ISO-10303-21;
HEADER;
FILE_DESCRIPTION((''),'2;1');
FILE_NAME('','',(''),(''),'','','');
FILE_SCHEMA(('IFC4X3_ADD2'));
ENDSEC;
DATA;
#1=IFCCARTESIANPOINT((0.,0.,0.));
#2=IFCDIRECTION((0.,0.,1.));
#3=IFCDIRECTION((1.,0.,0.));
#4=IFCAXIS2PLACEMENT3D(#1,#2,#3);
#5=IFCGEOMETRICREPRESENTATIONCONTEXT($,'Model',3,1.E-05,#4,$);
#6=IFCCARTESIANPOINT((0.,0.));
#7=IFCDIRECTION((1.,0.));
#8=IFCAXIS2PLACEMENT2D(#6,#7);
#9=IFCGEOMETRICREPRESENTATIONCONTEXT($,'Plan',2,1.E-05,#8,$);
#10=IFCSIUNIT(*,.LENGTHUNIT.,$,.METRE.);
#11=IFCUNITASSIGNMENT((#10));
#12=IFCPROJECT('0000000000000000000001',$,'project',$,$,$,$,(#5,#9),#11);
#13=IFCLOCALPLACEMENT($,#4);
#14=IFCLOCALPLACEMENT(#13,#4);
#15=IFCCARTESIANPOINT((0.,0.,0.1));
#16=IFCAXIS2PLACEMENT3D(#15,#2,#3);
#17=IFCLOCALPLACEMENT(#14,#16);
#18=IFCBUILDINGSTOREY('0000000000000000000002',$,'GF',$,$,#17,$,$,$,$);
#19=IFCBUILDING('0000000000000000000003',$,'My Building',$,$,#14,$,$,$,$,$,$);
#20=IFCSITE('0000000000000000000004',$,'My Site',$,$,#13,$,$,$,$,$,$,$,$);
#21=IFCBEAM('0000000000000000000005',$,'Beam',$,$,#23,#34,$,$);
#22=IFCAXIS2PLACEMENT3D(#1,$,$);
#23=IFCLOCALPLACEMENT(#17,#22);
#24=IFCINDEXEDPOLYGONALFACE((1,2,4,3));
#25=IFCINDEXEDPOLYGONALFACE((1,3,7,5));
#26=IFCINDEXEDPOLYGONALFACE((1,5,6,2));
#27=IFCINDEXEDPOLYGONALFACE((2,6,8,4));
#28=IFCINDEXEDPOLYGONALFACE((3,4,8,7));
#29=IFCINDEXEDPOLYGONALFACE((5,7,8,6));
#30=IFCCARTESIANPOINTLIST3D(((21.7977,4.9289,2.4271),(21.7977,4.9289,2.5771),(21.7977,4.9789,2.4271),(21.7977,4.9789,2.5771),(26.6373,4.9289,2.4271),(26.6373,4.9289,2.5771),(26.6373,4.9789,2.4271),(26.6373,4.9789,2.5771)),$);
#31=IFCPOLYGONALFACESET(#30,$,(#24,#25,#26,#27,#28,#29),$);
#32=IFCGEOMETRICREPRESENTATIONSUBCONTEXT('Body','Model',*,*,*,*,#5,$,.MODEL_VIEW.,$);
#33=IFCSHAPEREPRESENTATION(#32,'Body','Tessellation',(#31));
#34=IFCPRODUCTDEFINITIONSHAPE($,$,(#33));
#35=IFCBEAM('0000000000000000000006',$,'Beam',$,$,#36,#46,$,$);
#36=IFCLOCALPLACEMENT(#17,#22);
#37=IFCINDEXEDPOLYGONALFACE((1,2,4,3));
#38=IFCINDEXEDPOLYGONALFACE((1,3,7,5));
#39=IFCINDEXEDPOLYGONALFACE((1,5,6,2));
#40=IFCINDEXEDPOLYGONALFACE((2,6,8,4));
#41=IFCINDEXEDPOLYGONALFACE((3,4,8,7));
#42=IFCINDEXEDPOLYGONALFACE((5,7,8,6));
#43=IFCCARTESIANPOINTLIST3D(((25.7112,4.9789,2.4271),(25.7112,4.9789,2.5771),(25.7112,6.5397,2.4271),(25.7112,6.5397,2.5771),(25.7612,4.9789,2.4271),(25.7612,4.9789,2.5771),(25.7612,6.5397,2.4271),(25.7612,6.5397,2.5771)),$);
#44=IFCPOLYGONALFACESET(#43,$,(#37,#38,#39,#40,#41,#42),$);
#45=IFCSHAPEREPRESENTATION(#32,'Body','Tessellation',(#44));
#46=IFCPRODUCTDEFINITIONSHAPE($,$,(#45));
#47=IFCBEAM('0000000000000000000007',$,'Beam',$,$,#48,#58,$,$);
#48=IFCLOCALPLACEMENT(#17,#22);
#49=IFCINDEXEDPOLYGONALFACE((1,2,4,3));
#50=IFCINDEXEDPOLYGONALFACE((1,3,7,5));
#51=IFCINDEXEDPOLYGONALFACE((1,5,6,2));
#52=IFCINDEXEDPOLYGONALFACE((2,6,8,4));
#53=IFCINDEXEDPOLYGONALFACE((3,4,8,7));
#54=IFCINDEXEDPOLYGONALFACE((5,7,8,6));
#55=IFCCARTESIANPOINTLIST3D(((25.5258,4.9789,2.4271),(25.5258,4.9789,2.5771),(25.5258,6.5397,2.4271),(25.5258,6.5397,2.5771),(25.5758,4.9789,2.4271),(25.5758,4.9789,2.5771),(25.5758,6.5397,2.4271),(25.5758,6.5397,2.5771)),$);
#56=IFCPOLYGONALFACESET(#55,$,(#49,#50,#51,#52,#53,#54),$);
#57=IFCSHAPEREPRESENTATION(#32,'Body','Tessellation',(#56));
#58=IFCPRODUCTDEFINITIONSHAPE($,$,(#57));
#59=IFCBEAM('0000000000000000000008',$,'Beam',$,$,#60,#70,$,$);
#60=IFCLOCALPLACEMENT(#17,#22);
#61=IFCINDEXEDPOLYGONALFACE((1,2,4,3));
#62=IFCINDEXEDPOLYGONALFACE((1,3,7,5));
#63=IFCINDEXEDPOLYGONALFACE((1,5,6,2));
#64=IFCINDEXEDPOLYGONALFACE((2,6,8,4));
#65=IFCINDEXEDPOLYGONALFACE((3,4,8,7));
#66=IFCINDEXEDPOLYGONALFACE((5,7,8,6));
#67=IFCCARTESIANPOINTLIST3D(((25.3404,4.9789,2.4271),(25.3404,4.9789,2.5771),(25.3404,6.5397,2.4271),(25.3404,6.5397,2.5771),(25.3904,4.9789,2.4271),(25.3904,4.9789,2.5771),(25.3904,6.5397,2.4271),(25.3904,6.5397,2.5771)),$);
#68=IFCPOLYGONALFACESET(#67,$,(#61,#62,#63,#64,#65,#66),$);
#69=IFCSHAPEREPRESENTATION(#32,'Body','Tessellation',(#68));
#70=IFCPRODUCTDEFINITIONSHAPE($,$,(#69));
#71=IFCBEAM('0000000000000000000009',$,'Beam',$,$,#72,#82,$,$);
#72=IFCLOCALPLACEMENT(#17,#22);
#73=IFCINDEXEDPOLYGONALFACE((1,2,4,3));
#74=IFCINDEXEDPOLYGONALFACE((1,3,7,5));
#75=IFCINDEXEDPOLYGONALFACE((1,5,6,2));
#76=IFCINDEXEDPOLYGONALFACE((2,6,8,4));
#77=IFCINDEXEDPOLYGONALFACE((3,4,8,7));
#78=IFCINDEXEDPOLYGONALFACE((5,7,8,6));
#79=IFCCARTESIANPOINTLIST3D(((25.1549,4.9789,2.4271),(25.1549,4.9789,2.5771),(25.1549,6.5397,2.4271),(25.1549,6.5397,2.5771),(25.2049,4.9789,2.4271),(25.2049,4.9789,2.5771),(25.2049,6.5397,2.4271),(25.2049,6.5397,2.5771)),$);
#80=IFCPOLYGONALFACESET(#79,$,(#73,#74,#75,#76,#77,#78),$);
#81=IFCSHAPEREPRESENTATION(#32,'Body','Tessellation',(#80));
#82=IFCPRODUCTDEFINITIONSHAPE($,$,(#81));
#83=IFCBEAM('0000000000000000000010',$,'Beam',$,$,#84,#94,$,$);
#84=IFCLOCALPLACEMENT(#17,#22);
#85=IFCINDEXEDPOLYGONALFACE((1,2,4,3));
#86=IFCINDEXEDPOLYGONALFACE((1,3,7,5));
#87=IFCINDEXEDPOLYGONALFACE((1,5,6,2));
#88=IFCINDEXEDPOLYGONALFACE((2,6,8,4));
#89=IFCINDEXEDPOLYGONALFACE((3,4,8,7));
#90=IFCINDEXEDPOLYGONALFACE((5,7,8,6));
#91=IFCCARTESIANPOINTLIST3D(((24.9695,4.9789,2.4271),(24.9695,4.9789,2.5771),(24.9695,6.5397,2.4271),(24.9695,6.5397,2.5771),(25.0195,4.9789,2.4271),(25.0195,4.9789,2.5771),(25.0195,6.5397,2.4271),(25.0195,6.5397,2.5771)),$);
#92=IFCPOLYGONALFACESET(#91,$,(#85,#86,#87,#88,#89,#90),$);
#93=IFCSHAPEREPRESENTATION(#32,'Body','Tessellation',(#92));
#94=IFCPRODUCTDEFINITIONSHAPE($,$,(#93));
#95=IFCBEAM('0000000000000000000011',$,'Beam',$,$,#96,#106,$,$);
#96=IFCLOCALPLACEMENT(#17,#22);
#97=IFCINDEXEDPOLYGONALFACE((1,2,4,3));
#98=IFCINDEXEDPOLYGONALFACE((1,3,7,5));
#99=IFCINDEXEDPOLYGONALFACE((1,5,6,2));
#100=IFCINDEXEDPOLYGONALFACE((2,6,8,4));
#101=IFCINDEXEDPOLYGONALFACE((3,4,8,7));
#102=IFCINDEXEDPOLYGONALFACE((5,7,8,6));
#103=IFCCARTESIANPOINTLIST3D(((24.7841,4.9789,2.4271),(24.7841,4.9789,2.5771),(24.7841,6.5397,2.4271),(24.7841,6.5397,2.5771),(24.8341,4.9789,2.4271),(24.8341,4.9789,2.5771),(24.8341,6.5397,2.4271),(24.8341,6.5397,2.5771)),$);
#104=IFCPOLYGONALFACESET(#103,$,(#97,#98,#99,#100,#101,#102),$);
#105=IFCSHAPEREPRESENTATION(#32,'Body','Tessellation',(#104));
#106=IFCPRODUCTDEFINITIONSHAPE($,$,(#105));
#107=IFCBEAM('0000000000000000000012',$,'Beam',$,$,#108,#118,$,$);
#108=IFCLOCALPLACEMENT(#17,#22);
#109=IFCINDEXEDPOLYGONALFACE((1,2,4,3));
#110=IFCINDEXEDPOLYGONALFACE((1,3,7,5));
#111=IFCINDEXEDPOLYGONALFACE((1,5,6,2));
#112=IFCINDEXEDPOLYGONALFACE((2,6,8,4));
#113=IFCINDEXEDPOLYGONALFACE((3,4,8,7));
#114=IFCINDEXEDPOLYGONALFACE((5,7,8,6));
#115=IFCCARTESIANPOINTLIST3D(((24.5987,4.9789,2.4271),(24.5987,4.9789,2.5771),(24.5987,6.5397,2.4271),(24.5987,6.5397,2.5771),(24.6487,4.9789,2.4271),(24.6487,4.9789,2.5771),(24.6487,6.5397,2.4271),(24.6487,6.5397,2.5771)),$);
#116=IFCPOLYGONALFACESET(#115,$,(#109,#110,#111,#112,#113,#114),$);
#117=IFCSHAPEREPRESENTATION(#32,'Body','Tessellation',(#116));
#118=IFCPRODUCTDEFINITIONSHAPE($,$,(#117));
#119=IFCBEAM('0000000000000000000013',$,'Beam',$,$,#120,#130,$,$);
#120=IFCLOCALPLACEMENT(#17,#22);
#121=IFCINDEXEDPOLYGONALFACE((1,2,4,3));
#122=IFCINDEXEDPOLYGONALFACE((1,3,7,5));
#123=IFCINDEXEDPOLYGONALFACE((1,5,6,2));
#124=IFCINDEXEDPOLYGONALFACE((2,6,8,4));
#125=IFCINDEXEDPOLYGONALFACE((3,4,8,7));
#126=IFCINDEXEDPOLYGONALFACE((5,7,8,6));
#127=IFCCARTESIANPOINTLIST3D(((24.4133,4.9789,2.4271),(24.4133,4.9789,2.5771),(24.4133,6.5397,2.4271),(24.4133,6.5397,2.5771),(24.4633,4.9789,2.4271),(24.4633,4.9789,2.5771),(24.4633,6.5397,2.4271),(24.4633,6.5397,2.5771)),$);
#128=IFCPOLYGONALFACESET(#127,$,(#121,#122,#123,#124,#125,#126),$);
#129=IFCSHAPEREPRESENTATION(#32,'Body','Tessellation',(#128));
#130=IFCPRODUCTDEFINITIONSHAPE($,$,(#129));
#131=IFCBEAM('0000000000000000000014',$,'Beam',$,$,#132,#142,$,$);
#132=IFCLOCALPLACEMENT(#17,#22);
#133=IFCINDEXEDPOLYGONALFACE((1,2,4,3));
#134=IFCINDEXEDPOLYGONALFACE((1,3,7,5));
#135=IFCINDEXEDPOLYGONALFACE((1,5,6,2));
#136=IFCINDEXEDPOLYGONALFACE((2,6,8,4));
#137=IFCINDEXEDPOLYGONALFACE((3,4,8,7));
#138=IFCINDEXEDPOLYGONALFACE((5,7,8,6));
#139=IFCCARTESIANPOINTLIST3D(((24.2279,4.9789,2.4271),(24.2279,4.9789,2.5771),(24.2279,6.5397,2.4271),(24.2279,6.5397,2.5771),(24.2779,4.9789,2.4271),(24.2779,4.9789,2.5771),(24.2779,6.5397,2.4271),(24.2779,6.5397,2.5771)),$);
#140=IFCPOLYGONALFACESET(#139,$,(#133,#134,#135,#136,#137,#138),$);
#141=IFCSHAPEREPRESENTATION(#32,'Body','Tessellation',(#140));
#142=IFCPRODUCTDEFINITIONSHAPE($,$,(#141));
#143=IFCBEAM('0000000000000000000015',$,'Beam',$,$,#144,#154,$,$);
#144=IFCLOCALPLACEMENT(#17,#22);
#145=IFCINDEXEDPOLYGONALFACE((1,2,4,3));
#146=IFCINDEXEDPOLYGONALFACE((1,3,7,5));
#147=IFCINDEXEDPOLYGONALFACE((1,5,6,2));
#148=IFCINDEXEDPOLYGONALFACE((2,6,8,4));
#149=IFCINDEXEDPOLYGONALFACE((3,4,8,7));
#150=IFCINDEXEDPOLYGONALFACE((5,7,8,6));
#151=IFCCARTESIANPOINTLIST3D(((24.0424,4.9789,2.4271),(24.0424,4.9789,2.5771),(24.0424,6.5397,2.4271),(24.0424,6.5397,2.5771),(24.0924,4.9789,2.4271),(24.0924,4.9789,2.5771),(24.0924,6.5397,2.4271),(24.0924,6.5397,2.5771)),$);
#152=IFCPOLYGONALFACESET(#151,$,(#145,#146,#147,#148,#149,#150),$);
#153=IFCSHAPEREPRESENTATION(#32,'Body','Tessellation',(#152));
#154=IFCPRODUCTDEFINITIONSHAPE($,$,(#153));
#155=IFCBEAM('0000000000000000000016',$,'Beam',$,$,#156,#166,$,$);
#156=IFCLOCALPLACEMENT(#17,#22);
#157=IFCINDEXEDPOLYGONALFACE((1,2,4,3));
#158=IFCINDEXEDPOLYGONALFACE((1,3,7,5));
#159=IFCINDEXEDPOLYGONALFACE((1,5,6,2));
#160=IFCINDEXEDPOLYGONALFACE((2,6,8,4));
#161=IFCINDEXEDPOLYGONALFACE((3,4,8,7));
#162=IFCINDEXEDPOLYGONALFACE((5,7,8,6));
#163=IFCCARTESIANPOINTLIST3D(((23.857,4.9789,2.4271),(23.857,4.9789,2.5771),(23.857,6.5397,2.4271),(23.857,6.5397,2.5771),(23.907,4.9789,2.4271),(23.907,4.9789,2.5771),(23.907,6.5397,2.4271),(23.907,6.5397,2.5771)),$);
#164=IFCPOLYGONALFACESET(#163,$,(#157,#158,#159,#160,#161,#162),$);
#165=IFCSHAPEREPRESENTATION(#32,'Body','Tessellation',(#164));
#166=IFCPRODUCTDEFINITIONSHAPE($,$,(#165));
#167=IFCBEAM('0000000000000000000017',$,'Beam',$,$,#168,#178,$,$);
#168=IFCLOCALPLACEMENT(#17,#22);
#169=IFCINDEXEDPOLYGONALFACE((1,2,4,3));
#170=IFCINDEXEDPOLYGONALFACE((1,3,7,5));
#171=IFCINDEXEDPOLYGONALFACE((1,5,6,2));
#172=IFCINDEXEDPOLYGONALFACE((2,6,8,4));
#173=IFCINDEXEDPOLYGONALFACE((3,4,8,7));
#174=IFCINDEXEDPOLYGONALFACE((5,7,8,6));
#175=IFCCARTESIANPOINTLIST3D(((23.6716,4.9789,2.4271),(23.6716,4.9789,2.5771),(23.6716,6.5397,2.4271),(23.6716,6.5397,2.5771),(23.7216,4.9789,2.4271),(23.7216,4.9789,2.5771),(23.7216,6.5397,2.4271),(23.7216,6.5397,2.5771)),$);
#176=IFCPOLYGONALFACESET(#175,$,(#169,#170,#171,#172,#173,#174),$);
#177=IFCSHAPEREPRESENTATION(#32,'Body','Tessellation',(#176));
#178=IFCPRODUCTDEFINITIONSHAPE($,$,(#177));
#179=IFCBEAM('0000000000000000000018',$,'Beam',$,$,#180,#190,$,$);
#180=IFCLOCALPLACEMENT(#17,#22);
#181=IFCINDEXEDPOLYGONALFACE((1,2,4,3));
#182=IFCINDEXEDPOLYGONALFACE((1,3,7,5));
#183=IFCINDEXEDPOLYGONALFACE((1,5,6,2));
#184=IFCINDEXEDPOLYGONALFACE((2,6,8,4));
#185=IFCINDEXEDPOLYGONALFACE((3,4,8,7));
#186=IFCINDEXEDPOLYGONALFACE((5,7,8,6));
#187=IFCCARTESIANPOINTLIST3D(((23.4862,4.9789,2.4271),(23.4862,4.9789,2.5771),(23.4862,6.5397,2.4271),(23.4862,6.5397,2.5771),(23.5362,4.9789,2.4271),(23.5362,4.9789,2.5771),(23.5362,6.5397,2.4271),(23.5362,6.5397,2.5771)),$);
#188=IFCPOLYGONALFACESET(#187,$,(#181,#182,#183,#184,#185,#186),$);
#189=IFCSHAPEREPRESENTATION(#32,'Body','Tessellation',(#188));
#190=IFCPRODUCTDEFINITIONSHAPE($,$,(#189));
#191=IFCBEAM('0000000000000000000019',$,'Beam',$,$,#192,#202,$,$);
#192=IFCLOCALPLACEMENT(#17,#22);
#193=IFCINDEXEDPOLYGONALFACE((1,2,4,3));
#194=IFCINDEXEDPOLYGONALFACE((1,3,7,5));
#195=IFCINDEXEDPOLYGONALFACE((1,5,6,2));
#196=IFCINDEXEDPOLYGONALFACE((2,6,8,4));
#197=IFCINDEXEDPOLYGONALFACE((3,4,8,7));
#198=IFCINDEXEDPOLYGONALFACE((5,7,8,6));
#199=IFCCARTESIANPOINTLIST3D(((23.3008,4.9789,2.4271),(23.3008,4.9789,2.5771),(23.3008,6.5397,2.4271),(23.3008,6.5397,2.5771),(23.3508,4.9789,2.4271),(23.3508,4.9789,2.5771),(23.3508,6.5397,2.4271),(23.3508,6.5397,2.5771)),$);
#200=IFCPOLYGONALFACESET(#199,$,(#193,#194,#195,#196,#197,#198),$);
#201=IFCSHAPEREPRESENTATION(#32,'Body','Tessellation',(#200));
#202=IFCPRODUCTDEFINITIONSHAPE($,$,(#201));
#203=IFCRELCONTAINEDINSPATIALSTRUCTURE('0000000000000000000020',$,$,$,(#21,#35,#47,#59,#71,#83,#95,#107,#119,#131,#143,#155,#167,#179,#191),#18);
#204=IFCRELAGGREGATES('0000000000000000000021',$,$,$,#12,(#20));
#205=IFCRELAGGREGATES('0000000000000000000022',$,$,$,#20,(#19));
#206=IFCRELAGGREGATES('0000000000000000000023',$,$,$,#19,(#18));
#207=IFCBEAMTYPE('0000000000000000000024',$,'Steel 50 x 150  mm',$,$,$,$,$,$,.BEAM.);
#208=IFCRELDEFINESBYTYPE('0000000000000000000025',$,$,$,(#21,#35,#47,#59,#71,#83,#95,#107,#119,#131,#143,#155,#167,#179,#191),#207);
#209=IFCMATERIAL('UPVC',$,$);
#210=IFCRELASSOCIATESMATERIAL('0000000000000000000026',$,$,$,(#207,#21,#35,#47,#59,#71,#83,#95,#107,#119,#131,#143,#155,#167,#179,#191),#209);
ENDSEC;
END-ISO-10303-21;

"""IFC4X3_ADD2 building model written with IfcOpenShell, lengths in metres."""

from ifc_helpers import new_model, si_unit, frame, origin_with_axes, origin_2d_with_axis, place, context, subcontext, project, spatial, rectangle, extrude, material, material_profile, profile_set, profile_usage, type_object, element, save


model = new_model("IFC4X3_ADD2")

# Units and contexts
model_context = context("Model", 3, precision=1e-05, world=origin_with_axes())
plan_context = context("Plan", 2, precision=1e-05, world=origin_2d_with_axis())
body_context_1 = subcontext(model_context, "Body", "Model", "MODEL_VIEW")
ifc_project = project(units=[si_unit("LENGTHUNIT", "METRE")], contexts=[model_context, plan_context])

# Site, building, storey
site_placement = place(None, origin_with_axes())
site = spatial("IfcSite", under=ifc_project, at=site_placement, Name="My Site")
building_placement = place(site_placement, origin_with_axes())
building = spatial("IfcBuilding", under=site, at=building_placement, Name="My Building")
storey_placement = place(building_placement, frame((0.0, 0.0, 0.1), z_axis=(0.0, 0.0, 1.0), x_axis=(1.0, 0.0, 0.0)))
storey = spatial("IfcBuildingStorey", under=building, at=storey_placement, Name="GF")

# Beams
ifc_material_1 = material(Name="UPVC")
ifc_material_profile_1 = material_profile(ifc_material_1, rectangle(XDim=0.05, YDim=0.15))
ifc_profile_set_1 = profile_set([ifc_material_profile_1])
ifc_profile_usage_1 = profile_usage(ifc_profile_set_1)
beam_type_1 = type_object("IfcBeamType", Name="Steel 50 x 150  mm", PredefinedType="BEAM", material=ifc_profile_set_1)
beam_1_placement = place(storey_placement, frame((21.7977, 4.9539, 2.5021), z_axis=(1.0, 0.0, 0.0), x_axis=(0.0, 1.0, 0.0)))
element("IfcBeam", 1, at=beam_1_placement, inside=storey, type_object=beam_type_1, material=ifc_profile_usage_1, Name="Beam", context=body_context_1, shape_type="SweptSolid", body=[
    extrude(rectangle(XDim=0.05, YDim=0.15), origin_with_axes(), (0.0, 0.0, 1.0), 4.8396),
])
ifc_profile_usage_2 = profile_usage(ifc_profile_set_1)
beam_2_placement = place(storey_placement, frame((25.7362, 6.5397, 2.5021), z_axis=(0.0, -1.0, 0.0), x_axis=(1.0, 0.0, 0.0)))
element("IfcBeam", 2, at=beam_2_placement, inside=storey, type_object=beam_type_1, material=ifc_profile_usage_2, Name="Beam", context=body_context_1, shape_type="SweptSolid", body=[
    extrude(rectangle(XDim=0.05, YDim=0.15), origin_with_axes(), (0.0, 0.0, 1.0), 1.5608),
])
ifc_profile_usage_3 = profile_usage(ifc_profile_set_1)
beam_3_placement = place(storey_placement, frame((25.5508, 6.5397, 2.5021), z_axis=(0.0, -1.0, 0.0), x_axis=(1.0, 0.0, 0.0)))
element("IfcBeam", 3, at=beam_3_placement, inside=storey, type_object=beam_type_1, material=ifc_profile_usage_3, Name="Beam", context=body_context_1, shape_type="SweptSolid", body=[
    extrude(rectangle(XDim=0.05, YDim=0.15), origin_with_axes(), (0.0, 0.0, 1.0), 1.5608),
])
ifc_profile_usage_4 = profile_usage(ifc_profile_set_1)
beam_4_placement = place(storey_placement, frame((25.3654, 6.5397, 2.5021), z_axis=(0.0, -1.0, 0.0), x_axis=(1.0, 0.0, 0.0)))
element("IfcBeam", 4, at=beam_4_placement, inside=storey, type_object=beam_type_1, material=ifc_profile_usage_4, Name="Beam", context=body_context_1, shape_type="SweptSolid", body=[
    extrude(rectangle(XDim=0.05, YDim=0.15), origin_with_axes(), (0.0, 0.0, 1.0), 1.5608),
])
ifc_profile_usage_5 = profile_usage(ifc_profile_set_1)
beam_5_placement = place(storey_placement, frame((25.1799, 6.5397, 2.5021), z_axis=(0.0, -1.0, 0.0), x_axis=(1.0, 0.0, 0.0)))
element("IfcBeam", 5, at=beam_5_placement, inside=storey, type_object=beam_type_1, material=ifc_profile_usage_5, Name="Beam", context=body_context_1, shape_type="SweptSolid", body=[
    extrude(rectangle(XDim=0.05, YDim=0.15), origin_with_axes(), (0.0, 0.0, 1.0), 1.5608),
])
ifc_profile_usage_6 = profile_usage(ifc_profile_set_1)
beam_6_placement = place(storey_placement, frame((24.9945, 6.5397, 2.5021), z_axis=(0.0, -1.0, 0.0), x_axis=(1.0, 0.0, 0.0)))
element("IfcBeam", 6, at=beam_6_placement, inside=storey, type_object=beam_type_1, material=ifc_profile_usage_6, Name="Beam", context=body_context_1, shape_type="SweptSolid", body=[
    extrude(rectangle(XDim=0.05, YDim=0.15), origin_with_axes(), (0.0, 0.0, 1.0), 1.5608),
])
ifc_profile_usage_7 = profile_usage(ifc_profile_set_1)
beam_7_placement = place(storey_placement, frame((24.8091, 6.5397, 2.5021), z_axis=(0.0, -1.0, 0.0), x_axis=(1.0, 0.0, 0.0)))
element("IfcBeam", 7, at=beam_7_placement, inside=storey, type_object=beam_type_1, material=ifc_profile_usage_7, Name="Beam", context=body_context_1, shape_type="SweptSolid", body=[
    extrude(rectangle(XDim=0.05, YDim=0.15), origin_with_axes(), (0.0, 0.0, 1.0), 1.5608),
])
ifc_profile_usage_8 = profile_usage(ifc_profile_set_1)
beam_8_placement = place(storey_placement, frame((24.6237, 6.5397, 2.5021), z_axis=(0.0, -1.0, 0.0), x_axis=(1.0, 0.0, 0.0)))
element("IfcBeam", 8, at=beam_8_placement, inside=storey, type_object=beam_type_1, material=ifc_profile_usage_8, Name="Beam", context=body_context_1, shape_type="SweptSolid", body=[
    extrude(rectangle(XDim=0.05, YDim=0.15), origin_with_axes(), (0.0, 0.0, 1.0), 1.5608),
])
ifc_profile_usage_9 = profile_usage(ifc_profile_set_1)
beam_9_placement = place(storey_placement, frame((24.4383, 6.5397, 2.5021), z_axis=(0.0, -1.0, 0.0), x_axis=(1.0, 0.0, 0.0)))
element("IfcBeam", 9, at=beam_9_placement, inside=storey, type_object=beam_type_1, material=ifc_profile_usage_9, Name="Beam", context=body_context_1, shape_type="SweptSolid", body=[
    extrude(rectangle(XDim=0.05, YDim=0.15), origin_with_axes(), (0.0, 0.0, 1.0), 1.5608),
])
ifc_profile_usage_10 = profile_usage(ifc_profile_set_1)
beam_10_placement = place(storey_placement, frame((24.2529, 6.5397, 2.5021), z_axis=(0.0, -1.0, 0.0), x_axis=(1.0, 0.0, 0.0)))
element("IfcBeam", 10, at=beam_10_placement, inside=storey, type_object=beam_type_1, material=ifc_profile_usage_10, Name="Beam", context=body_context_1, shape_type="SweptSolid", body=[
    extrude(rectangle(XDim=0.05, YDim=0.15), origin_with_axes(), (0.0, 0.0, 1.0), 1.5608),
])
ifc_profile_usage_11 = profile_usage(ifc_profile_set_1)
beam_11_placement = place(storey_placement, frame((24.0674, 6.5397, 2.5021), z_axis=(0.0, -1.0, 0.0), x_axis=(1.0, 0.0, 0.0)))
element("IfcBeam", 11, at=beam_11_placement, inside=storey, type_object=beam_type_1, material=ifc_profile_usage_11, Name="Beam", context=body_context_1, shape_type="SweptSolid", body=[
    extrude(rectangle(XDim=0.05, YDim=0.15), origin_with_axes(), (0.0, 0.0, 1.0), 1.5608),
])
ifc_profile_usage_12 = profile_usage(ifc_profile_set_1)
beam_12_placement = place(storey_placement, frame((23.882, 6.5397, 2.5021), z_axis=(0.0, -1.0, 0.0), x_axis=(1.0, 0.0, 0.0)))
element("IfcBeam", 12, at=beam_12_placement, inside=storey, type_object=beam_type_1, material=ifc_profile_usage_12, Name="Beam", context=body_context_1, shape_type="SweptSolid", body=[
    extrude(rectangle(XDim=0.05, YDim=0.15), origin_with_axes(), (0.0, 0.0, 1.0), 1.5608),
])
ifc_profile_usage_13 = profile_usage(ifc_profile_set_1)
beam_13_placement = place(storey_placement, frame((23.6966, 6.5397, 2.5021), z_axis=(0.0, -1.0, 0.0), x_axis=(1.0, 0.0, 0.0)))
element("IfcBeam", 13, at=beam_13_placement, inside=storey, type_object=beam_type_1, material=ifc_profile_usage_13, Name="Beam", context=body_context_1, shape_type="SweptSolid", body=[
    extrude(rectangle(XDim=0.05, YDim=0.15), origin_with_axes(), (0.0, 0.0, 1.0), 1.5608),
])
ifc_profile_usage_14 = profile_usage(ifc_profile_set_1)
beam_14_placement = place(storey_placement, frame((23.5112, 6.5397, 2.5021), z_axis=(0.0, -1.0, 0.0), x_axis=(1.0, 0.0, 0.0)))
element("IfcBeam", 14, at=beam_14_placement, inside=storey, type_object=beam_type_1, material=ifc_profile_usage_14, Name="Beam", context=body_context_1, shape_type="SweptSolid", body=[
    extrude(rectangle(XDim=0.05, YDim=0.15), origin_with_axes(), (0.0, 0.0, 1.0), 1.5608),
])
ifc_profile_usage_15 = profile_usage(ifc_profile_set_1)
beam_15_placement = place(storey_placement, frame((23.3258, 6.5397, 2.5021), z_axis=(0.0, -1.0, 0.0), x_axis=(1.0, 0.0, 0.0)))
element("IfcBeam", 15, at=beam_15_placement, inside=storey, type_object=beam_type_1, material=ifc_profile_usage_15, Name="Beam", context=body_context_1, shape_type="SweptSolid", body=[
    extrude(rectangle(XDim=0.05, YDim=0.15), origin_with_axes(), (0.0, 0.0, 1.0), 1.5608),
])

save(model, "model.ifc")
